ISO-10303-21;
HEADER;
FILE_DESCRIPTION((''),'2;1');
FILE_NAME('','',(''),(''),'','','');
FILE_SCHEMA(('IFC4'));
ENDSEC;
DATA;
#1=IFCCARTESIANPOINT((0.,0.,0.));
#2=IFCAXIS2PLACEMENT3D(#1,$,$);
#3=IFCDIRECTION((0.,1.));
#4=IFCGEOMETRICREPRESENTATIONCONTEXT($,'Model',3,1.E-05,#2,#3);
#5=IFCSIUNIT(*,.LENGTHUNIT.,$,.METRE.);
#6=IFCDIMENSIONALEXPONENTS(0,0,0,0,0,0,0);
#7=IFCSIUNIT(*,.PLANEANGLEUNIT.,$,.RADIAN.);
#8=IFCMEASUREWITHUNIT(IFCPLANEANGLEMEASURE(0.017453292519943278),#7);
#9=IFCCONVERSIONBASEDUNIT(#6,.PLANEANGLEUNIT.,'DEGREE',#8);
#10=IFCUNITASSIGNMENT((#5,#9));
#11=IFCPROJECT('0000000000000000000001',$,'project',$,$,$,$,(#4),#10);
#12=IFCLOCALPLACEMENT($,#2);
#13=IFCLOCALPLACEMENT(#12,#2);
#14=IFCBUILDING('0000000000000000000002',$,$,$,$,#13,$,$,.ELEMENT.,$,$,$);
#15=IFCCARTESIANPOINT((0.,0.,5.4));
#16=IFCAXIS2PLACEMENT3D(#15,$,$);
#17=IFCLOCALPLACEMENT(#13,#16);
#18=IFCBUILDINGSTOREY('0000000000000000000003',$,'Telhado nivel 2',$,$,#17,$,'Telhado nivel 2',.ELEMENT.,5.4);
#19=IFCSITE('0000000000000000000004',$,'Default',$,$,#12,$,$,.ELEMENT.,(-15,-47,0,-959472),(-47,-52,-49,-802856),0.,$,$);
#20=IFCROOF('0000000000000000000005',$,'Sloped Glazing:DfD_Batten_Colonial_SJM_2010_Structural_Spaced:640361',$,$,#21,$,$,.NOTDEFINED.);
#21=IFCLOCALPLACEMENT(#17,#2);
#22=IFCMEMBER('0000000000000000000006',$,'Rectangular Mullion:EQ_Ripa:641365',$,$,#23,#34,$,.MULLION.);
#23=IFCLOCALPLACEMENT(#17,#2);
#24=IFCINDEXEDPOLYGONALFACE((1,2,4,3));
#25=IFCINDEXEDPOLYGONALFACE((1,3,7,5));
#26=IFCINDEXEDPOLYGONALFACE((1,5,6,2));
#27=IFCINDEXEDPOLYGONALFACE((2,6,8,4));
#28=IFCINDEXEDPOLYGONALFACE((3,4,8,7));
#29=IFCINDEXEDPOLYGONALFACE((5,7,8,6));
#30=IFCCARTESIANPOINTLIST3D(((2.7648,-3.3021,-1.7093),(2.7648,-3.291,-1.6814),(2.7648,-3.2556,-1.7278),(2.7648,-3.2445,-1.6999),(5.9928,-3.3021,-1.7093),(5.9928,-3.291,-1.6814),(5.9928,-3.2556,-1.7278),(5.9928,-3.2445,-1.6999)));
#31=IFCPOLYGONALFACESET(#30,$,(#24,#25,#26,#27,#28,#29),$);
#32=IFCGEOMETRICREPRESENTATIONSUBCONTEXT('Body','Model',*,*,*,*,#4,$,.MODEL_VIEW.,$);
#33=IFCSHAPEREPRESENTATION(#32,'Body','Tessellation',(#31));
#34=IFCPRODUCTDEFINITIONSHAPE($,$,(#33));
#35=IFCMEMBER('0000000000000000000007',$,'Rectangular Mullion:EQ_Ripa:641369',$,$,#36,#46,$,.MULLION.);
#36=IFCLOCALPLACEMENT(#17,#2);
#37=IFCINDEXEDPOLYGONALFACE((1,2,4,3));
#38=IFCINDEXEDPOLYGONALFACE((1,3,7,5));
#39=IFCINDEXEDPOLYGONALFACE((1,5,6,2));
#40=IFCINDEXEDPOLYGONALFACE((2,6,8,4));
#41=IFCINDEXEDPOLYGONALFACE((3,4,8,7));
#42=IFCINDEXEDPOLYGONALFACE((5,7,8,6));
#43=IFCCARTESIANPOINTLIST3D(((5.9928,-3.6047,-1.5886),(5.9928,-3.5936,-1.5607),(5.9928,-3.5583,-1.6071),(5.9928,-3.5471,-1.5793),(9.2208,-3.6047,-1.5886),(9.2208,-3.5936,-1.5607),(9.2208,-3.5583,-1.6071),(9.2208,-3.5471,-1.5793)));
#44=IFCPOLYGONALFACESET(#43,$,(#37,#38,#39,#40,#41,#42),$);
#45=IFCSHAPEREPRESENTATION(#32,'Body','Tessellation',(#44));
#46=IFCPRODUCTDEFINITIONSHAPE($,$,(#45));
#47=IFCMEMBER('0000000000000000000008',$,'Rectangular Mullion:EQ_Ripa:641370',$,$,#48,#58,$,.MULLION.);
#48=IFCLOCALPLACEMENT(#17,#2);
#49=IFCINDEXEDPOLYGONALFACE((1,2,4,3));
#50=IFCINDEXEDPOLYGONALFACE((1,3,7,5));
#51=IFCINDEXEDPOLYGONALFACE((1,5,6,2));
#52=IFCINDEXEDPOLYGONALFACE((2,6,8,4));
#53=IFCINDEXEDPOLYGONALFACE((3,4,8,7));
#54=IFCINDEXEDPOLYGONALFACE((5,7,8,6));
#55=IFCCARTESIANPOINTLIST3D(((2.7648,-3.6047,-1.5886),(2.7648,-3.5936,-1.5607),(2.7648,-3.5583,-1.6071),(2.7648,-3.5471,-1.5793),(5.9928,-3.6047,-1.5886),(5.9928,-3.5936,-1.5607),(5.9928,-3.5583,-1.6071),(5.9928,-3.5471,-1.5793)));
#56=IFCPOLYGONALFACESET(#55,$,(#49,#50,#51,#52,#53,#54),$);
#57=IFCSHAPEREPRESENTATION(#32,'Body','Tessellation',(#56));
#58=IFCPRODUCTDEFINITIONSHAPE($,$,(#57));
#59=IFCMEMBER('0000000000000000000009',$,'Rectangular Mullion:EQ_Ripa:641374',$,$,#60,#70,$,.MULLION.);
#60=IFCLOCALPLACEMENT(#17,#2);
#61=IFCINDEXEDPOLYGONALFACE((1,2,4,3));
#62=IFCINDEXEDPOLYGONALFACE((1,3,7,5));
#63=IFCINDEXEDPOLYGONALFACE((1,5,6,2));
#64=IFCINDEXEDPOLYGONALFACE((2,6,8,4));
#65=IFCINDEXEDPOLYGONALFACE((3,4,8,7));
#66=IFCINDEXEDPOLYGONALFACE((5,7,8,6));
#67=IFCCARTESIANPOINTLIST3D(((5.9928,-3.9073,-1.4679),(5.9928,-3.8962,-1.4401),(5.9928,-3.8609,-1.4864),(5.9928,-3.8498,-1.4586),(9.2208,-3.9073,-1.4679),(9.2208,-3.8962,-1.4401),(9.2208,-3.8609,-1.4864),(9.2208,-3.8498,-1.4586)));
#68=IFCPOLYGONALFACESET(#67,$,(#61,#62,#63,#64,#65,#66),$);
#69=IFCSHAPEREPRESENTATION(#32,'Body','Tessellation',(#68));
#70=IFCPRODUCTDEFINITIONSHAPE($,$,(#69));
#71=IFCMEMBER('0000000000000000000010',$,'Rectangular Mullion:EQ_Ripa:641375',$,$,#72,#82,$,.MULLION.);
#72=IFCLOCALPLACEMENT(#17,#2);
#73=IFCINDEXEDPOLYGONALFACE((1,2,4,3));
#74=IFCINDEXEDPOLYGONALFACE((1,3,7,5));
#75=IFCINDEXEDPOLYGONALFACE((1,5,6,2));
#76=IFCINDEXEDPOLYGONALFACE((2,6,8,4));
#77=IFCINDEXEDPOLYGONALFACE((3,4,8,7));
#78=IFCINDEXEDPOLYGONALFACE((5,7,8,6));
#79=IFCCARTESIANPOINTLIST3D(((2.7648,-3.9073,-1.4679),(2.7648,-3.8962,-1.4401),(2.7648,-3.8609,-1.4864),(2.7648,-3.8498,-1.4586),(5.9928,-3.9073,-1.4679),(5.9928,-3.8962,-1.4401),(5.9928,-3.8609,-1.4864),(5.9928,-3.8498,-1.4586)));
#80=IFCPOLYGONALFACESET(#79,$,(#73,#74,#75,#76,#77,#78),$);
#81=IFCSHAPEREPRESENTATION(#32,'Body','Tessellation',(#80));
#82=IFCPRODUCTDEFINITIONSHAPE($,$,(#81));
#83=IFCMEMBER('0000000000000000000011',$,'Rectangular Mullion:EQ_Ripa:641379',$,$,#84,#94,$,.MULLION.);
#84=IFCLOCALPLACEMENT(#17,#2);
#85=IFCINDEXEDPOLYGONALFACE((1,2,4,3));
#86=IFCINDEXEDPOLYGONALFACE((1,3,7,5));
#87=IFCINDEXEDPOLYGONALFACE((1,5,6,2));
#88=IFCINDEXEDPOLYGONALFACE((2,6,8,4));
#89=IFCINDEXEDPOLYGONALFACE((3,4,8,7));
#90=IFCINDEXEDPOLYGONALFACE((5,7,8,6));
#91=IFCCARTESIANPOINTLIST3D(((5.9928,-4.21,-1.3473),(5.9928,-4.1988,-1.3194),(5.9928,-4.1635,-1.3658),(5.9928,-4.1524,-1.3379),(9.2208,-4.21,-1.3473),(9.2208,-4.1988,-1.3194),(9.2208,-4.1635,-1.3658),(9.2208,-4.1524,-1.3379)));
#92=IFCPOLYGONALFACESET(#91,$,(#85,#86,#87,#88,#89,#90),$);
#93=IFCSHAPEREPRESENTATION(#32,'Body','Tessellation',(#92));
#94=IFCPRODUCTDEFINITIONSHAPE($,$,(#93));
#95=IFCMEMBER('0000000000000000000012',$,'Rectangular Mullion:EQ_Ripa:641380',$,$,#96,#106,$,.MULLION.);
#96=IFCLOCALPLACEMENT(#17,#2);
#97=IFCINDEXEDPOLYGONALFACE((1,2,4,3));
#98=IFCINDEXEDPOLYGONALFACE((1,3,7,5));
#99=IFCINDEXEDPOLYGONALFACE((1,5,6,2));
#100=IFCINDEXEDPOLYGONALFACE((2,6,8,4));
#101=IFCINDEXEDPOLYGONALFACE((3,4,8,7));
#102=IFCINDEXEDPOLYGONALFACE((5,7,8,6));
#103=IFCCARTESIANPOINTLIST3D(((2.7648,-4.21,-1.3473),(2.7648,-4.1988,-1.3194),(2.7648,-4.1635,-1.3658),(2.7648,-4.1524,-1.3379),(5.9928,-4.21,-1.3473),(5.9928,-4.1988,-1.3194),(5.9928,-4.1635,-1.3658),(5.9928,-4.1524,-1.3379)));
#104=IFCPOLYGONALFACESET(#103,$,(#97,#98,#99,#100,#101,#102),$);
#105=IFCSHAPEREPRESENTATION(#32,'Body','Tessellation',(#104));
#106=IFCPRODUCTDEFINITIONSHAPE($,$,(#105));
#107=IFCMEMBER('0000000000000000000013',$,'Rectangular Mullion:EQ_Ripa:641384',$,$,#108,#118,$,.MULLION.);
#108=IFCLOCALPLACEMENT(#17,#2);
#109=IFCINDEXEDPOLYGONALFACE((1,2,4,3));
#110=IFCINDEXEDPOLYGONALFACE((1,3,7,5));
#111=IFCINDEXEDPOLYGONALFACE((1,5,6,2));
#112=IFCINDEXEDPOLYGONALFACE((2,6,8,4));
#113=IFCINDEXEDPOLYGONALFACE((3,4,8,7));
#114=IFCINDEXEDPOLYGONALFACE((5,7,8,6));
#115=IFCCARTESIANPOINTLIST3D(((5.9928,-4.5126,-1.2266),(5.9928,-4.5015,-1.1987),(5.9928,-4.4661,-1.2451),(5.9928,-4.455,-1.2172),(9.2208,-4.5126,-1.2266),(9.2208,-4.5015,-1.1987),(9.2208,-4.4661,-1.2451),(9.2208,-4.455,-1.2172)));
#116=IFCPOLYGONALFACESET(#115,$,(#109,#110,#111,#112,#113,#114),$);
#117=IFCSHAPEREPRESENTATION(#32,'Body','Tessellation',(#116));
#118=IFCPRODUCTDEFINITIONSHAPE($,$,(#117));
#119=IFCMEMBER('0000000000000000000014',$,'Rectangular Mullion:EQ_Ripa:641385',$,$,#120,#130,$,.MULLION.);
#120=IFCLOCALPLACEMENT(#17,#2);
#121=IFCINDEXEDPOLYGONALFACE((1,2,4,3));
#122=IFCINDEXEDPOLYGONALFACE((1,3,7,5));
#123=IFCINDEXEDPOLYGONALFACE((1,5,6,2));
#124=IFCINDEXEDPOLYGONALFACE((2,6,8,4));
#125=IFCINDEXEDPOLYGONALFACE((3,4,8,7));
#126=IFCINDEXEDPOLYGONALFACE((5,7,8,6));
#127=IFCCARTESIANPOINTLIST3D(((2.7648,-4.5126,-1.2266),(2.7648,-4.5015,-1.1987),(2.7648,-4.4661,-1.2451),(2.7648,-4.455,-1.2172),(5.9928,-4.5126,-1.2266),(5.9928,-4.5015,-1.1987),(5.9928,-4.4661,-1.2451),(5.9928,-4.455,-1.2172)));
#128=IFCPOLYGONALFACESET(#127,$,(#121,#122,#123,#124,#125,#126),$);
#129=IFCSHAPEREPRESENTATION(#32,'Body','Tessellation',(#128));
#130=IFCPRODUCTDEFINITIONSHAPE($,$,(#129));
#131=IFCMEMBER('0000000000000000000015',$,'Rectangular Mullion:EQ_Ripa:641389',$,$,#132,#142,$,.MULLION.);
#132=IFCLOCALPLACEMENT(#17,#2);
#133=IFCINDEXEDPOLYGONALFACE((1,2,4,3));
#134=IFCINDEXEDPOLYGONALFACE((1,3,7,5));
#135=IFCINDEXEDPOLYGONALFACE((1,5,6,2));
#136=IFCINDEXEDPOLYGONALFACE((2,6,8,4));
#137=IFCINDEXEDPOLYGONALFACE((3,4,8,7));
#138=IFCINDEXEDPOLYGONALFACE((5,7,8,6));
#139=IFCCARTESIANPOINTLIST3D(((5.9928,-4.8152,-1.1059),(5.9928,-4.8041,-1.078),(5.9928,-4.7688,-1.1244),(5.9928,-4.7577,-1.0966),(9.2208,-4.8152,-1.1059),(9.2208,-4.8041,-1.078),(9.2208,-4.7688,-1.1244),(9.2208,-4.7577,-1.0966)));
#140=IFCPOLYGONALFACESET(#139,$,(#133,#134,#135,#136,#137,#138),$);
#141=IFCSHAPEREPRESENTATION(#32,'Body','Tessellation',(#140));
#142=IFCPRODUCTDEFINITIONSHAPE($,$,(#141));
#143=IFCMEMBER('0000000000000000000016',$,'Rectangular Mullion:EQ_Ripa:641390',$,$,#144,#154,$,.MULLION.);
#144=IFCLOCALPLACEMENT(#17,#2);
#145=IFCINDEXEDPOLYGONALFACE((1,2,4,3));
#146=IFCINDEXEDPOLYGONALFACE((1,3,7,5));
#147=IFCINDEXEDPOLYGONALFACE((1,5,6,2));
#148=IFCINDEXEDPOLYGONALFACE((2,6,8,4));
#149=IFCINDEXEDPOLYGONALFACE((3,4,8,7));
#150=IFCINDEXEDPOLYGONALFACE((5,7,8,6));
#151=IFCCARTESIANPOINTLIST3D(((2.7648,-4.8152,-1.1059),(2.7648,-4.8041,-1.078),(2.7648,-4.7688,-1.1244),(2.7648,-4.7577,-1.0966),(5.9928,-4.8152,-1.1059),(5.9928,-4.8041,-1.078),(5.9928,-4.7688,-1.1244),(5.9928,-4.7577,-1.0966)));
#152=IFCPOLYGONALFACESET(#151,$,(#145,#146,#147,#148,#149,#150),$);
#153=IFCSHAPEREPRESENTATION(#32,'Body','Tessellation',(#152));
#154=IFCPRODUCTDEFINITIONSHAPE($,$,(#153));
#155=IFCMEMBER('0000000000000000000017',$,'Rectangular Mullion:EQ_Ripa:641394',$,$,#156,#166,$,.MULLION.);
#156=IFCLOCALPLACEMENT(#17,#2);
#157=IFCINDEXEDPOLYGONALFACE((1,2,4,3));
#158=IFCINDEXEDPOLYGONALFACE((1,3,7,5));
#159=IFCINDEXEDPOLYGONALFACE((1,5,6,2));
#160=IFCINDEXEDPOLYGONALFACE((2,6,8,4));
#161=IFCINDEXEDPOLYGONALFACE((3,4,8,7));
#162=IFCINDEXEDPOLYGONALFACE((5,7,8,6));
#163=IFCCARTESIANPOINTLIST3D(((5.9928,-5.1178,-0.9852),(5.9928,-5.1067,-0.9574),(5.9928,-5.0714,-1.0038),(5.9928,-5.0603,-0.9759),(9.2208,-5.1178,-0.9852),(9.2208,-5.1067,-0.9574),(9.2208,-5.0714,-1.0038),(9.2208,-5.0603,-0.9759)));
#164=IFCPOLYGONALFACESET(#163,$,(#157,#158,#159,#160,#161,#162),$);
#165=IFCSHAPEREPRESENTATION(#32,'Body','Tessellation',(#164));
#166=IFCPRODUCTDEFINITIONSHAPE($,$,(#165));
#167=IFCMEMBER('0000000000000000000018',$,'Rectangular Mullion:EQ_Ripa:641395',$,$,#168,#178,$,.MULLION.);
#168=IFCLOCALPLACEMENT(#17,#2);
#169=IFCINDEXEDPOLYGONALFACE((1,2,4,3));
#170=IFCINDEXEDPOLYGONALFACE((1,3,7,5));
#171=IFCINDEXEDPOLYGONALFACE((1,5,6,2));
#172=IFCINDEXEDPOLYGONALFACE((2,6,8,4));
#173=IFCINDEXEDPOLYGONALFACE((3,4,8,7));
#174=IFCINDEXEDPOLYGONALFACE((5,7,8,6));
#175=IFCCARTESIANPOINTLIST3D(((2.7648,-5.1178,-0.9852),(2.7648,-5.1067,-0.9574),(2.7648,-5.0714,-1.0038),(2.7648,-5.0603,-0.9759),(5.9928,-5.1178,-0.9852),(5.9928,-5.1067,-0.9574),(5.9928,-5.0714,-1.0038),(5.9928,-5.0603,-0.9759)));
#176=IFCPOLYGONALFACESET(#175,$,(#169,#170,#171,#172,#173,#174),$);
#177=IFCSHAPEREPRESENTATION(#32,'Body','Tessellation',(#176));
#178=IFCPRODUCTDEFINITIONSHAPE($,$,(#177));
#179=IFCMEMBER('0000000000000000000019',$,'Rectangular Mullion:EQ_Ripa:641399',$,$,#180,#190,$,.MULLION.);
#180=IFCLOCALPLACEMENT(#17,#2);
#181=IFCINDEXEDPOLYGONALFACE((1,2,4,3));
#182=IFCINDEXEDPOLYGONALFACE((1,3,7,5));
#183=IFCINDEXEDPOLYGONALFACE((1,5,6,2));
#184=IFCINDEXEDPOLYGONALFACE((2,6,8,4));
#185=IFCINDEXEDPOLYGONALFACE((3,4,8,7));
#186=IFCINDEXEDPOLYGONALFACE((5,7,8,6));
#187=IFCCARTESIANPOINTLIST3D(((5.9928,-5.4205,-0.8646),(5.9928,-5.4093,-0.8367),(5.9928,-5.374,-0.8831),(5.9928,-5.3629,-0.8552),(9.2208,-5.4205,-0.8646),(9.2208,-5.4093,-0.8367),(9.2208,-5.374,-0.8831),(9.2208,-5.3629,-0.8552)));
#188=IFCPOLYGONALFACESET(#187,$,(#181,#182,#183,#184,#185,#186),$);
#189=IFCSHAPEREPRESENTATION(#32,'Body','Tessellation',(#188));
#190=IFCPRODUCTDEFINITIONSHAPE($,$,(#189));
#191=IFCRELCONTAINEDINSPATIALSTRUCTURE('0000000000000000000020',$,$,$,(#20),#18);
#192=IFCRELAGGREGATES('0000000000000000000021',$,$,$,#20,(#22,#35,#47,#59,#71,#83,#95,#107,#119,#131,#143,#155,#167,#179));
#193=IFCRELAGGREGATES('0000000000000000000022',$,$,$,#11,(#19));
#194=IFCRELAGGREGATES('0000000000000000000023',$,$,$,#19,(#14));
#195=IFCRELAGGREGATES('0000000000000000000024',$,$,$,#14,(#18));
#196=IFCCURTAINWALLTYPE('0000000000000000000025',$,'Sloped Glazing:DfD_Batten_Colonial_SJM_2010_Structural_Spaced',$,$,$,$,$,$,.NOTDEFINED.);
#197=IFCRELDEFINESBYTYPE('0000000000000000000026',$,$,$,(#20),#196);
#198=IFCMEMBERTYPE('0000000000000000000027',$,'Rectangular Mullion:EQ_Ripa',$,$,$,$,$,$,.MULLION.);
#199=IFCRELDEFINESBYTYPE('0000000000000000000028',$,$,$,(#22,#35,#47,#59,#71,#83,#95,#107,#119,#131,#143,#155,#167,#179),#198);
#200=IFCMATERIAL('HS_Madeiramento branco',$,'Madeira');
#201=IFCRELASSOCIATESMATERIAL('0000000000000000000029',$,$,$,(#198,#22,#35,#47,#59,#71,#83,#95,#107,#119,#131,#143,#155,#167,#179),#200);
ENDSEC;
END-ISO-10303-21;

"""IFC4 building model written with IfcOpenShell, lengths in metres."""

from ifc_helpers import new_model, entity, si_unit, converted_unit, direction, frame, origin, place, context, subcontext, project, spatial, indexed_curve, outline, extrude, source, transform, mapped, material, type_object, type_shapes, element, aggregate, save


model = new_model("IFC4")

# Units and contexts
model_context = context("Model", 3, precision=1e-05, world=origin(), true_north=direction((0.0, 1.0)))
body_context = subcontext(model_context, "Body", "Model", "MODEL_VIEW")
ifc_project = project(units=[si_unit("LENGTHUNIT", "METRE"), converted_unit("PLANEANGLEUNIT", "DEGREE", entity("IfcPlaneAngleMeasure", 0.017453292519943278), si_unit("PLANEANGLEUNIT", "RADIAN"), dimensions=[0, 0, 0, 0, 0, 0, 0])], contexts=[model_context])

# Site, building, storey
site_placement = place(None, origin())
site = spatial("IfcSite", under=ifc_project, at=site_placement, Name="Default", CompositionType="ELEMENT", RefLatitude=(-15, -47, 0, -959472), RefLongitude=(-47, -52, -49, -802856), RefElevation=0.0)
building_placement = place(site_placement, origin())
building = spatial("IfcBuilding", under=site, at=building_placement, CompositionType="ELEMENT")
storey_placement = place(building_placement, frame((0.0, 0.0, 5.4)))
storey = spatial("IfcBuildingStorey", under=building, at=storey_placement, Name="Telhado nivel 2", LongName="Telhado nivel 2", CompositionType="ELEMENT", Elevation=5.4)

# Roof, members
curtain_wall_type = type_object("IfcCurtainWallType", Name="Sloped Glazing:DfD_Batten_Colonial_SJM_2010_Structural_Spaced", PredefinedType="NOTDEFINED")
roof_placement = place(storey_placement, frame((0.0, 0.0, -5.4)))
roof = element("IfcRoof", 1, at=roof_placement, inside=storey, type_object=curtain_wall_type, Name="Sloped Glazing:DfD_Batten_Colonial_SJM_2010_Structural_Spaced:640361", PredefinedType="NOTDEFINED")
ifc_material = material(Name="HS_Madeiramento branco", Category="Madeira")
member_type_1 = type_object("IfcMemberType", Name="Rectangular Mullion:EQ_Ripa", PredefinedType="MULLION", material=ifc_material)
shared_shape_1 = source(origin(), body_context, "Body", "SweptSolid", [
    extrude(outline(indexed_curve([(-0.025, -0.015), (0.025, -0.015), (0.025, 0.015), (-0.025, 0.015), (-0.025, -0.015)], self_intersect=False)), frame((0.0, 0.0, -3.228), z_axis=(0.0, 0.0, 1.0), x_axis=(-1.0, 0.0, 0.0)), (0.0, 0.0, 1.0), 3.228),
])
type_shapes(member_type_1, [shared_shape_1])
member_1_placement = place(roof_placement, frame((5.9928, -3.2733, 3.6954), z_axis=(1.0, 0.0, 0.0), x_axis=(0.0, -0.928874, 0.370395)))
member_1 = element("IfcMember", 2, at=member_1_placement, type_object=member_type_1, material=ifc_material, Name="Rectangular Mullion:EQ_Ripa:641365", PredefinedType="MULLION", context=body_context, shape_type="MappedRepresentation", body=[
    mapped(shared_shape_1, transform((0.0, 0.0, 0.0), scale=1.0)),
])
member_2_placement = place(roof_placement, frame((9.2208, -3.5759, 3.8161), z_axis=(1.0, 0.0, 0.0), x_axis=(0.0, -0.928874, 0.370395)))
member_2 = element("IfcMember", 3, at=member_2_placement, type_object=member_type_1, material=ifc_material, Name="Rectangular Mullion:EQ_Ripa:641369", PredefinedType="MULLION", context=body_context, shape_type="MappedRepresentation", body=[
    mapped(shared_shape_1, transform((0.0, 0.0, 0.0), scale=1.0)),
])
member_3_placement = place(roof_placement, frame((5.9928, -3.5759, 3.8161), z_axis=(1.0, 0.0, 0.0), x_axis=(0.0, -0.928874, 0.370395)))
member_3 = element("IfcMember", 4, at=member_3_placement, type_object=member_type_1, material=ifc_material, Name="Rectangular Mullion:EQ_Ripa:641370", PredefinedType="MULLION", context=body_context, shape_type="MappedRepresentation", body=[
    mapped(shared_shape_1, transform((0.0, 0.0, 0.0), scale=1.0)),
])
member_4_placement = place(roof_placement, frame((9.2208, -3.8785, 3.9367), z_axis=(1.0, 0.0, 0.0), x_axis=(0.0, -0.928874, 0.370395)))
member_4 = element("IfcMember", 5, at=member_4_placement, type_object=member_type_1, material=ifc_material, Name="Rectangular Mullion:EQ_Ripa:641374", PredefinedType="MULLION", context=body_context, shape_type="MappedRepresentation", body=[
    mapped(shared_shape_1, transform((0.0, 0.0, 0.0), scale=1.0)),
])
member_5_placement = place(roof_placement, frame((5.9928, -3.8785, 3.9367), z_axis=(1.0, 0.0, 0.0), x_axis=(0.0, -0.928874, 0.370395)))
member_5 = element("IfcMember", 6, at=member_5_placement, type_object=member_type_1, material=ifc_material, Name="Rectangular Mullion:EQ_Ripa:641375", PredefinedType="MULLION", context=body_context, shape_type="MappedRepresentation", body=[
    mapped(shared_shape_1, transform((0.0, 0.0, 0.0), scale=1.0)),
])
member_6_placement = place(roof_placement, frame((9.2208, -4.1812, 4.0574), z_axis=(1.0, 0.0, 0.0), x_axis=(0.0, -0.928874, 0.370395)))
member_6 = element("IfcMember", 7, at=member_6_placement, type_object=member_type_1, material=ifc_material, Name="Rectangular Mullion:EQ_Ripa:641379", PredefinedType="MULLION", context=body_context, shape_type="MappedRepresentation", body=[
    mapped(shared_shape_1, transform((0.0, 0.0, 0.0), scale=1.0)),
])
member_7_placement = place(roof_placement, frame((5.9928, -4.1812, 4.0574), z_axis=(1.0, 0.0, 0.0), x_axis=(0.0, -0.928874, 0.370395)))
member_7 = element("IfcMember", 8, at=member_7_placement, type_object=member_type_1, material=ifc_material, Name="Rectangular Mullion:EQ_Ripa:641380", PredefinedType="MULLION", context=body_context, shape_type="MappedRepresentation", body=[
    mapped(shared_shape_1, transform((0.0, 0.0, 0.0), scale=1.0)),
])
member_8_placement = place(roof_placement, frame((9.2208, -4.4838, 4.1781), z_axis=(1.0, 0.0, 0.0), x_axis=(0.0, -0.928874, 0.370395)))
member_8 = element("IfcMember", 9, at=member_8_placement, type_object=member_type_1, material=ifc_material, Name="Rectangular Mullion:EQ_Ripa:641384", PredefinedType="MULLION", context=body_context, shape_type="MappedRepresentation", body=[
    mapped(shared_shape_1, transform((0.0, 0.0, 0.0), scale=1.0)),
])
member_9_placement = place(roof_placement, frame((5.9928, -4.4838, 4.1781), z_axis=(1.0, 0.0, 0.0), x_axis=(0.0, -0.928874, 0.370395)))
member_9 = element("IfcMember", 10, at=member_9_placement, type_object=member_type_1, material=ifc_material, Name="Rectangular Mullion:EQ_Ripa:641385", PredefinedType="MULLION", context=body_context, shape_type="MappedRepresentation", body=[
    mapped(shared_shape_1, transform((0.0, 0.0, 0.0), scale=1.0)),
])
member_10_placement = place(roof_placement, frame((9.2208, -4.7864, 4.2988), z_axis=(1.0, 0.0, 0.0), x_axis=(0.0, -0.928874, 0.370395)))
member_10 = element("IfcMember", 11, at=member_10_placement, type_object=member_type_1, material=ifc_material, Name="Rectangular Mullion:EQ_Ripa:641389", PredefinedType="MULLION", context=body_context, shape_type="MappedRepresentation", body=[
    mapped(shared_shape_1, transform((0.0, 0.0, 0.0), scale=1.0)),
])
member_11_placement = place(roof_placement, frame((5.9928, -4.7864, 4.2988), z_axis=(1.0, 0.0, 0.0), x_axis=(0.0, -0.928874, 0.370395)))
member_11 = element("IfcMember", 12, at=member_11_placement, type_object=member_type_1, material=ifc_material, Name="Rectangular Mullion:EQ_Ripa:641390", PredefinedType="MULLION", context=body_context, shape_type="MappedRepresentation", body=[
    mapped(shared_shape_1, transform((0.0, 0.0, 0.0), scale=1.0)),
])
member_12_placement = place(roof_placement, frame((9.2208, -5.0891, 4.4194), z_axis=(1.0, 0.0, 0.0), x_axis=(0.0, -0.928874, 0.370395)))
member_12 = element("IfcMember", 13, at=member_12_placement, type_object=member_type_1, material=ifc_material, Name="Rectangular Mullion:EQ_Ripa:641394", PredefinedType="MULLION", context=body_context, shape_type="MappedRepresentation", body=[
    mapped(shared_shape_1, transform((0.0, 0.0, 0.0), scale=1.0)),
])
member_13_placement = place(roof_placement, frame((5.9928, -5.0891, 4.4194), z_axis=(1.0, 0.0, 0.0), x_axis=(0.0, -0.928874, 0.370395)))
member_13 = element("IfcMember", 14, at=member_13_placement, type_object=member_type_1, material=ifc_material, Name="Rectangular Mullion:EQ_Ripa:641395", PredefinedType="MULLION", context=body_context, shape_type="MappedRepresentation", body=[
    mapped(shared_shape_1, transform((0.0, 0.0, 0.0), scale=1.0)),
])
member_14_placement = place(roof_placement, frame((9.2208, -5.3917, 4.5401), z_axis=(1.0, 0.0, 0.0), x_axis=(0.0, -0.928874, 0.370395)))
member_14 = element("IfcMember", 15, at=member_14_placement, type_object=member_type_1, material=ifc_material, Name="Rectangular Mullion:EQ_Ripa:641399", PredefinedType="MULLION", context=body_context, shape_type="MappedRepresentation", body=[
    mapped(shared_shape_1, transform((0.0, 0.0, 0.0), scale=1.0)),
])
aggregate(roof, [member_1, member_2, member_3, member_4, member_5, member_6, member_7, member_8, member_9, member_10, member_11, member_12, member_13, member_14])

save(model, "model.ifc")
